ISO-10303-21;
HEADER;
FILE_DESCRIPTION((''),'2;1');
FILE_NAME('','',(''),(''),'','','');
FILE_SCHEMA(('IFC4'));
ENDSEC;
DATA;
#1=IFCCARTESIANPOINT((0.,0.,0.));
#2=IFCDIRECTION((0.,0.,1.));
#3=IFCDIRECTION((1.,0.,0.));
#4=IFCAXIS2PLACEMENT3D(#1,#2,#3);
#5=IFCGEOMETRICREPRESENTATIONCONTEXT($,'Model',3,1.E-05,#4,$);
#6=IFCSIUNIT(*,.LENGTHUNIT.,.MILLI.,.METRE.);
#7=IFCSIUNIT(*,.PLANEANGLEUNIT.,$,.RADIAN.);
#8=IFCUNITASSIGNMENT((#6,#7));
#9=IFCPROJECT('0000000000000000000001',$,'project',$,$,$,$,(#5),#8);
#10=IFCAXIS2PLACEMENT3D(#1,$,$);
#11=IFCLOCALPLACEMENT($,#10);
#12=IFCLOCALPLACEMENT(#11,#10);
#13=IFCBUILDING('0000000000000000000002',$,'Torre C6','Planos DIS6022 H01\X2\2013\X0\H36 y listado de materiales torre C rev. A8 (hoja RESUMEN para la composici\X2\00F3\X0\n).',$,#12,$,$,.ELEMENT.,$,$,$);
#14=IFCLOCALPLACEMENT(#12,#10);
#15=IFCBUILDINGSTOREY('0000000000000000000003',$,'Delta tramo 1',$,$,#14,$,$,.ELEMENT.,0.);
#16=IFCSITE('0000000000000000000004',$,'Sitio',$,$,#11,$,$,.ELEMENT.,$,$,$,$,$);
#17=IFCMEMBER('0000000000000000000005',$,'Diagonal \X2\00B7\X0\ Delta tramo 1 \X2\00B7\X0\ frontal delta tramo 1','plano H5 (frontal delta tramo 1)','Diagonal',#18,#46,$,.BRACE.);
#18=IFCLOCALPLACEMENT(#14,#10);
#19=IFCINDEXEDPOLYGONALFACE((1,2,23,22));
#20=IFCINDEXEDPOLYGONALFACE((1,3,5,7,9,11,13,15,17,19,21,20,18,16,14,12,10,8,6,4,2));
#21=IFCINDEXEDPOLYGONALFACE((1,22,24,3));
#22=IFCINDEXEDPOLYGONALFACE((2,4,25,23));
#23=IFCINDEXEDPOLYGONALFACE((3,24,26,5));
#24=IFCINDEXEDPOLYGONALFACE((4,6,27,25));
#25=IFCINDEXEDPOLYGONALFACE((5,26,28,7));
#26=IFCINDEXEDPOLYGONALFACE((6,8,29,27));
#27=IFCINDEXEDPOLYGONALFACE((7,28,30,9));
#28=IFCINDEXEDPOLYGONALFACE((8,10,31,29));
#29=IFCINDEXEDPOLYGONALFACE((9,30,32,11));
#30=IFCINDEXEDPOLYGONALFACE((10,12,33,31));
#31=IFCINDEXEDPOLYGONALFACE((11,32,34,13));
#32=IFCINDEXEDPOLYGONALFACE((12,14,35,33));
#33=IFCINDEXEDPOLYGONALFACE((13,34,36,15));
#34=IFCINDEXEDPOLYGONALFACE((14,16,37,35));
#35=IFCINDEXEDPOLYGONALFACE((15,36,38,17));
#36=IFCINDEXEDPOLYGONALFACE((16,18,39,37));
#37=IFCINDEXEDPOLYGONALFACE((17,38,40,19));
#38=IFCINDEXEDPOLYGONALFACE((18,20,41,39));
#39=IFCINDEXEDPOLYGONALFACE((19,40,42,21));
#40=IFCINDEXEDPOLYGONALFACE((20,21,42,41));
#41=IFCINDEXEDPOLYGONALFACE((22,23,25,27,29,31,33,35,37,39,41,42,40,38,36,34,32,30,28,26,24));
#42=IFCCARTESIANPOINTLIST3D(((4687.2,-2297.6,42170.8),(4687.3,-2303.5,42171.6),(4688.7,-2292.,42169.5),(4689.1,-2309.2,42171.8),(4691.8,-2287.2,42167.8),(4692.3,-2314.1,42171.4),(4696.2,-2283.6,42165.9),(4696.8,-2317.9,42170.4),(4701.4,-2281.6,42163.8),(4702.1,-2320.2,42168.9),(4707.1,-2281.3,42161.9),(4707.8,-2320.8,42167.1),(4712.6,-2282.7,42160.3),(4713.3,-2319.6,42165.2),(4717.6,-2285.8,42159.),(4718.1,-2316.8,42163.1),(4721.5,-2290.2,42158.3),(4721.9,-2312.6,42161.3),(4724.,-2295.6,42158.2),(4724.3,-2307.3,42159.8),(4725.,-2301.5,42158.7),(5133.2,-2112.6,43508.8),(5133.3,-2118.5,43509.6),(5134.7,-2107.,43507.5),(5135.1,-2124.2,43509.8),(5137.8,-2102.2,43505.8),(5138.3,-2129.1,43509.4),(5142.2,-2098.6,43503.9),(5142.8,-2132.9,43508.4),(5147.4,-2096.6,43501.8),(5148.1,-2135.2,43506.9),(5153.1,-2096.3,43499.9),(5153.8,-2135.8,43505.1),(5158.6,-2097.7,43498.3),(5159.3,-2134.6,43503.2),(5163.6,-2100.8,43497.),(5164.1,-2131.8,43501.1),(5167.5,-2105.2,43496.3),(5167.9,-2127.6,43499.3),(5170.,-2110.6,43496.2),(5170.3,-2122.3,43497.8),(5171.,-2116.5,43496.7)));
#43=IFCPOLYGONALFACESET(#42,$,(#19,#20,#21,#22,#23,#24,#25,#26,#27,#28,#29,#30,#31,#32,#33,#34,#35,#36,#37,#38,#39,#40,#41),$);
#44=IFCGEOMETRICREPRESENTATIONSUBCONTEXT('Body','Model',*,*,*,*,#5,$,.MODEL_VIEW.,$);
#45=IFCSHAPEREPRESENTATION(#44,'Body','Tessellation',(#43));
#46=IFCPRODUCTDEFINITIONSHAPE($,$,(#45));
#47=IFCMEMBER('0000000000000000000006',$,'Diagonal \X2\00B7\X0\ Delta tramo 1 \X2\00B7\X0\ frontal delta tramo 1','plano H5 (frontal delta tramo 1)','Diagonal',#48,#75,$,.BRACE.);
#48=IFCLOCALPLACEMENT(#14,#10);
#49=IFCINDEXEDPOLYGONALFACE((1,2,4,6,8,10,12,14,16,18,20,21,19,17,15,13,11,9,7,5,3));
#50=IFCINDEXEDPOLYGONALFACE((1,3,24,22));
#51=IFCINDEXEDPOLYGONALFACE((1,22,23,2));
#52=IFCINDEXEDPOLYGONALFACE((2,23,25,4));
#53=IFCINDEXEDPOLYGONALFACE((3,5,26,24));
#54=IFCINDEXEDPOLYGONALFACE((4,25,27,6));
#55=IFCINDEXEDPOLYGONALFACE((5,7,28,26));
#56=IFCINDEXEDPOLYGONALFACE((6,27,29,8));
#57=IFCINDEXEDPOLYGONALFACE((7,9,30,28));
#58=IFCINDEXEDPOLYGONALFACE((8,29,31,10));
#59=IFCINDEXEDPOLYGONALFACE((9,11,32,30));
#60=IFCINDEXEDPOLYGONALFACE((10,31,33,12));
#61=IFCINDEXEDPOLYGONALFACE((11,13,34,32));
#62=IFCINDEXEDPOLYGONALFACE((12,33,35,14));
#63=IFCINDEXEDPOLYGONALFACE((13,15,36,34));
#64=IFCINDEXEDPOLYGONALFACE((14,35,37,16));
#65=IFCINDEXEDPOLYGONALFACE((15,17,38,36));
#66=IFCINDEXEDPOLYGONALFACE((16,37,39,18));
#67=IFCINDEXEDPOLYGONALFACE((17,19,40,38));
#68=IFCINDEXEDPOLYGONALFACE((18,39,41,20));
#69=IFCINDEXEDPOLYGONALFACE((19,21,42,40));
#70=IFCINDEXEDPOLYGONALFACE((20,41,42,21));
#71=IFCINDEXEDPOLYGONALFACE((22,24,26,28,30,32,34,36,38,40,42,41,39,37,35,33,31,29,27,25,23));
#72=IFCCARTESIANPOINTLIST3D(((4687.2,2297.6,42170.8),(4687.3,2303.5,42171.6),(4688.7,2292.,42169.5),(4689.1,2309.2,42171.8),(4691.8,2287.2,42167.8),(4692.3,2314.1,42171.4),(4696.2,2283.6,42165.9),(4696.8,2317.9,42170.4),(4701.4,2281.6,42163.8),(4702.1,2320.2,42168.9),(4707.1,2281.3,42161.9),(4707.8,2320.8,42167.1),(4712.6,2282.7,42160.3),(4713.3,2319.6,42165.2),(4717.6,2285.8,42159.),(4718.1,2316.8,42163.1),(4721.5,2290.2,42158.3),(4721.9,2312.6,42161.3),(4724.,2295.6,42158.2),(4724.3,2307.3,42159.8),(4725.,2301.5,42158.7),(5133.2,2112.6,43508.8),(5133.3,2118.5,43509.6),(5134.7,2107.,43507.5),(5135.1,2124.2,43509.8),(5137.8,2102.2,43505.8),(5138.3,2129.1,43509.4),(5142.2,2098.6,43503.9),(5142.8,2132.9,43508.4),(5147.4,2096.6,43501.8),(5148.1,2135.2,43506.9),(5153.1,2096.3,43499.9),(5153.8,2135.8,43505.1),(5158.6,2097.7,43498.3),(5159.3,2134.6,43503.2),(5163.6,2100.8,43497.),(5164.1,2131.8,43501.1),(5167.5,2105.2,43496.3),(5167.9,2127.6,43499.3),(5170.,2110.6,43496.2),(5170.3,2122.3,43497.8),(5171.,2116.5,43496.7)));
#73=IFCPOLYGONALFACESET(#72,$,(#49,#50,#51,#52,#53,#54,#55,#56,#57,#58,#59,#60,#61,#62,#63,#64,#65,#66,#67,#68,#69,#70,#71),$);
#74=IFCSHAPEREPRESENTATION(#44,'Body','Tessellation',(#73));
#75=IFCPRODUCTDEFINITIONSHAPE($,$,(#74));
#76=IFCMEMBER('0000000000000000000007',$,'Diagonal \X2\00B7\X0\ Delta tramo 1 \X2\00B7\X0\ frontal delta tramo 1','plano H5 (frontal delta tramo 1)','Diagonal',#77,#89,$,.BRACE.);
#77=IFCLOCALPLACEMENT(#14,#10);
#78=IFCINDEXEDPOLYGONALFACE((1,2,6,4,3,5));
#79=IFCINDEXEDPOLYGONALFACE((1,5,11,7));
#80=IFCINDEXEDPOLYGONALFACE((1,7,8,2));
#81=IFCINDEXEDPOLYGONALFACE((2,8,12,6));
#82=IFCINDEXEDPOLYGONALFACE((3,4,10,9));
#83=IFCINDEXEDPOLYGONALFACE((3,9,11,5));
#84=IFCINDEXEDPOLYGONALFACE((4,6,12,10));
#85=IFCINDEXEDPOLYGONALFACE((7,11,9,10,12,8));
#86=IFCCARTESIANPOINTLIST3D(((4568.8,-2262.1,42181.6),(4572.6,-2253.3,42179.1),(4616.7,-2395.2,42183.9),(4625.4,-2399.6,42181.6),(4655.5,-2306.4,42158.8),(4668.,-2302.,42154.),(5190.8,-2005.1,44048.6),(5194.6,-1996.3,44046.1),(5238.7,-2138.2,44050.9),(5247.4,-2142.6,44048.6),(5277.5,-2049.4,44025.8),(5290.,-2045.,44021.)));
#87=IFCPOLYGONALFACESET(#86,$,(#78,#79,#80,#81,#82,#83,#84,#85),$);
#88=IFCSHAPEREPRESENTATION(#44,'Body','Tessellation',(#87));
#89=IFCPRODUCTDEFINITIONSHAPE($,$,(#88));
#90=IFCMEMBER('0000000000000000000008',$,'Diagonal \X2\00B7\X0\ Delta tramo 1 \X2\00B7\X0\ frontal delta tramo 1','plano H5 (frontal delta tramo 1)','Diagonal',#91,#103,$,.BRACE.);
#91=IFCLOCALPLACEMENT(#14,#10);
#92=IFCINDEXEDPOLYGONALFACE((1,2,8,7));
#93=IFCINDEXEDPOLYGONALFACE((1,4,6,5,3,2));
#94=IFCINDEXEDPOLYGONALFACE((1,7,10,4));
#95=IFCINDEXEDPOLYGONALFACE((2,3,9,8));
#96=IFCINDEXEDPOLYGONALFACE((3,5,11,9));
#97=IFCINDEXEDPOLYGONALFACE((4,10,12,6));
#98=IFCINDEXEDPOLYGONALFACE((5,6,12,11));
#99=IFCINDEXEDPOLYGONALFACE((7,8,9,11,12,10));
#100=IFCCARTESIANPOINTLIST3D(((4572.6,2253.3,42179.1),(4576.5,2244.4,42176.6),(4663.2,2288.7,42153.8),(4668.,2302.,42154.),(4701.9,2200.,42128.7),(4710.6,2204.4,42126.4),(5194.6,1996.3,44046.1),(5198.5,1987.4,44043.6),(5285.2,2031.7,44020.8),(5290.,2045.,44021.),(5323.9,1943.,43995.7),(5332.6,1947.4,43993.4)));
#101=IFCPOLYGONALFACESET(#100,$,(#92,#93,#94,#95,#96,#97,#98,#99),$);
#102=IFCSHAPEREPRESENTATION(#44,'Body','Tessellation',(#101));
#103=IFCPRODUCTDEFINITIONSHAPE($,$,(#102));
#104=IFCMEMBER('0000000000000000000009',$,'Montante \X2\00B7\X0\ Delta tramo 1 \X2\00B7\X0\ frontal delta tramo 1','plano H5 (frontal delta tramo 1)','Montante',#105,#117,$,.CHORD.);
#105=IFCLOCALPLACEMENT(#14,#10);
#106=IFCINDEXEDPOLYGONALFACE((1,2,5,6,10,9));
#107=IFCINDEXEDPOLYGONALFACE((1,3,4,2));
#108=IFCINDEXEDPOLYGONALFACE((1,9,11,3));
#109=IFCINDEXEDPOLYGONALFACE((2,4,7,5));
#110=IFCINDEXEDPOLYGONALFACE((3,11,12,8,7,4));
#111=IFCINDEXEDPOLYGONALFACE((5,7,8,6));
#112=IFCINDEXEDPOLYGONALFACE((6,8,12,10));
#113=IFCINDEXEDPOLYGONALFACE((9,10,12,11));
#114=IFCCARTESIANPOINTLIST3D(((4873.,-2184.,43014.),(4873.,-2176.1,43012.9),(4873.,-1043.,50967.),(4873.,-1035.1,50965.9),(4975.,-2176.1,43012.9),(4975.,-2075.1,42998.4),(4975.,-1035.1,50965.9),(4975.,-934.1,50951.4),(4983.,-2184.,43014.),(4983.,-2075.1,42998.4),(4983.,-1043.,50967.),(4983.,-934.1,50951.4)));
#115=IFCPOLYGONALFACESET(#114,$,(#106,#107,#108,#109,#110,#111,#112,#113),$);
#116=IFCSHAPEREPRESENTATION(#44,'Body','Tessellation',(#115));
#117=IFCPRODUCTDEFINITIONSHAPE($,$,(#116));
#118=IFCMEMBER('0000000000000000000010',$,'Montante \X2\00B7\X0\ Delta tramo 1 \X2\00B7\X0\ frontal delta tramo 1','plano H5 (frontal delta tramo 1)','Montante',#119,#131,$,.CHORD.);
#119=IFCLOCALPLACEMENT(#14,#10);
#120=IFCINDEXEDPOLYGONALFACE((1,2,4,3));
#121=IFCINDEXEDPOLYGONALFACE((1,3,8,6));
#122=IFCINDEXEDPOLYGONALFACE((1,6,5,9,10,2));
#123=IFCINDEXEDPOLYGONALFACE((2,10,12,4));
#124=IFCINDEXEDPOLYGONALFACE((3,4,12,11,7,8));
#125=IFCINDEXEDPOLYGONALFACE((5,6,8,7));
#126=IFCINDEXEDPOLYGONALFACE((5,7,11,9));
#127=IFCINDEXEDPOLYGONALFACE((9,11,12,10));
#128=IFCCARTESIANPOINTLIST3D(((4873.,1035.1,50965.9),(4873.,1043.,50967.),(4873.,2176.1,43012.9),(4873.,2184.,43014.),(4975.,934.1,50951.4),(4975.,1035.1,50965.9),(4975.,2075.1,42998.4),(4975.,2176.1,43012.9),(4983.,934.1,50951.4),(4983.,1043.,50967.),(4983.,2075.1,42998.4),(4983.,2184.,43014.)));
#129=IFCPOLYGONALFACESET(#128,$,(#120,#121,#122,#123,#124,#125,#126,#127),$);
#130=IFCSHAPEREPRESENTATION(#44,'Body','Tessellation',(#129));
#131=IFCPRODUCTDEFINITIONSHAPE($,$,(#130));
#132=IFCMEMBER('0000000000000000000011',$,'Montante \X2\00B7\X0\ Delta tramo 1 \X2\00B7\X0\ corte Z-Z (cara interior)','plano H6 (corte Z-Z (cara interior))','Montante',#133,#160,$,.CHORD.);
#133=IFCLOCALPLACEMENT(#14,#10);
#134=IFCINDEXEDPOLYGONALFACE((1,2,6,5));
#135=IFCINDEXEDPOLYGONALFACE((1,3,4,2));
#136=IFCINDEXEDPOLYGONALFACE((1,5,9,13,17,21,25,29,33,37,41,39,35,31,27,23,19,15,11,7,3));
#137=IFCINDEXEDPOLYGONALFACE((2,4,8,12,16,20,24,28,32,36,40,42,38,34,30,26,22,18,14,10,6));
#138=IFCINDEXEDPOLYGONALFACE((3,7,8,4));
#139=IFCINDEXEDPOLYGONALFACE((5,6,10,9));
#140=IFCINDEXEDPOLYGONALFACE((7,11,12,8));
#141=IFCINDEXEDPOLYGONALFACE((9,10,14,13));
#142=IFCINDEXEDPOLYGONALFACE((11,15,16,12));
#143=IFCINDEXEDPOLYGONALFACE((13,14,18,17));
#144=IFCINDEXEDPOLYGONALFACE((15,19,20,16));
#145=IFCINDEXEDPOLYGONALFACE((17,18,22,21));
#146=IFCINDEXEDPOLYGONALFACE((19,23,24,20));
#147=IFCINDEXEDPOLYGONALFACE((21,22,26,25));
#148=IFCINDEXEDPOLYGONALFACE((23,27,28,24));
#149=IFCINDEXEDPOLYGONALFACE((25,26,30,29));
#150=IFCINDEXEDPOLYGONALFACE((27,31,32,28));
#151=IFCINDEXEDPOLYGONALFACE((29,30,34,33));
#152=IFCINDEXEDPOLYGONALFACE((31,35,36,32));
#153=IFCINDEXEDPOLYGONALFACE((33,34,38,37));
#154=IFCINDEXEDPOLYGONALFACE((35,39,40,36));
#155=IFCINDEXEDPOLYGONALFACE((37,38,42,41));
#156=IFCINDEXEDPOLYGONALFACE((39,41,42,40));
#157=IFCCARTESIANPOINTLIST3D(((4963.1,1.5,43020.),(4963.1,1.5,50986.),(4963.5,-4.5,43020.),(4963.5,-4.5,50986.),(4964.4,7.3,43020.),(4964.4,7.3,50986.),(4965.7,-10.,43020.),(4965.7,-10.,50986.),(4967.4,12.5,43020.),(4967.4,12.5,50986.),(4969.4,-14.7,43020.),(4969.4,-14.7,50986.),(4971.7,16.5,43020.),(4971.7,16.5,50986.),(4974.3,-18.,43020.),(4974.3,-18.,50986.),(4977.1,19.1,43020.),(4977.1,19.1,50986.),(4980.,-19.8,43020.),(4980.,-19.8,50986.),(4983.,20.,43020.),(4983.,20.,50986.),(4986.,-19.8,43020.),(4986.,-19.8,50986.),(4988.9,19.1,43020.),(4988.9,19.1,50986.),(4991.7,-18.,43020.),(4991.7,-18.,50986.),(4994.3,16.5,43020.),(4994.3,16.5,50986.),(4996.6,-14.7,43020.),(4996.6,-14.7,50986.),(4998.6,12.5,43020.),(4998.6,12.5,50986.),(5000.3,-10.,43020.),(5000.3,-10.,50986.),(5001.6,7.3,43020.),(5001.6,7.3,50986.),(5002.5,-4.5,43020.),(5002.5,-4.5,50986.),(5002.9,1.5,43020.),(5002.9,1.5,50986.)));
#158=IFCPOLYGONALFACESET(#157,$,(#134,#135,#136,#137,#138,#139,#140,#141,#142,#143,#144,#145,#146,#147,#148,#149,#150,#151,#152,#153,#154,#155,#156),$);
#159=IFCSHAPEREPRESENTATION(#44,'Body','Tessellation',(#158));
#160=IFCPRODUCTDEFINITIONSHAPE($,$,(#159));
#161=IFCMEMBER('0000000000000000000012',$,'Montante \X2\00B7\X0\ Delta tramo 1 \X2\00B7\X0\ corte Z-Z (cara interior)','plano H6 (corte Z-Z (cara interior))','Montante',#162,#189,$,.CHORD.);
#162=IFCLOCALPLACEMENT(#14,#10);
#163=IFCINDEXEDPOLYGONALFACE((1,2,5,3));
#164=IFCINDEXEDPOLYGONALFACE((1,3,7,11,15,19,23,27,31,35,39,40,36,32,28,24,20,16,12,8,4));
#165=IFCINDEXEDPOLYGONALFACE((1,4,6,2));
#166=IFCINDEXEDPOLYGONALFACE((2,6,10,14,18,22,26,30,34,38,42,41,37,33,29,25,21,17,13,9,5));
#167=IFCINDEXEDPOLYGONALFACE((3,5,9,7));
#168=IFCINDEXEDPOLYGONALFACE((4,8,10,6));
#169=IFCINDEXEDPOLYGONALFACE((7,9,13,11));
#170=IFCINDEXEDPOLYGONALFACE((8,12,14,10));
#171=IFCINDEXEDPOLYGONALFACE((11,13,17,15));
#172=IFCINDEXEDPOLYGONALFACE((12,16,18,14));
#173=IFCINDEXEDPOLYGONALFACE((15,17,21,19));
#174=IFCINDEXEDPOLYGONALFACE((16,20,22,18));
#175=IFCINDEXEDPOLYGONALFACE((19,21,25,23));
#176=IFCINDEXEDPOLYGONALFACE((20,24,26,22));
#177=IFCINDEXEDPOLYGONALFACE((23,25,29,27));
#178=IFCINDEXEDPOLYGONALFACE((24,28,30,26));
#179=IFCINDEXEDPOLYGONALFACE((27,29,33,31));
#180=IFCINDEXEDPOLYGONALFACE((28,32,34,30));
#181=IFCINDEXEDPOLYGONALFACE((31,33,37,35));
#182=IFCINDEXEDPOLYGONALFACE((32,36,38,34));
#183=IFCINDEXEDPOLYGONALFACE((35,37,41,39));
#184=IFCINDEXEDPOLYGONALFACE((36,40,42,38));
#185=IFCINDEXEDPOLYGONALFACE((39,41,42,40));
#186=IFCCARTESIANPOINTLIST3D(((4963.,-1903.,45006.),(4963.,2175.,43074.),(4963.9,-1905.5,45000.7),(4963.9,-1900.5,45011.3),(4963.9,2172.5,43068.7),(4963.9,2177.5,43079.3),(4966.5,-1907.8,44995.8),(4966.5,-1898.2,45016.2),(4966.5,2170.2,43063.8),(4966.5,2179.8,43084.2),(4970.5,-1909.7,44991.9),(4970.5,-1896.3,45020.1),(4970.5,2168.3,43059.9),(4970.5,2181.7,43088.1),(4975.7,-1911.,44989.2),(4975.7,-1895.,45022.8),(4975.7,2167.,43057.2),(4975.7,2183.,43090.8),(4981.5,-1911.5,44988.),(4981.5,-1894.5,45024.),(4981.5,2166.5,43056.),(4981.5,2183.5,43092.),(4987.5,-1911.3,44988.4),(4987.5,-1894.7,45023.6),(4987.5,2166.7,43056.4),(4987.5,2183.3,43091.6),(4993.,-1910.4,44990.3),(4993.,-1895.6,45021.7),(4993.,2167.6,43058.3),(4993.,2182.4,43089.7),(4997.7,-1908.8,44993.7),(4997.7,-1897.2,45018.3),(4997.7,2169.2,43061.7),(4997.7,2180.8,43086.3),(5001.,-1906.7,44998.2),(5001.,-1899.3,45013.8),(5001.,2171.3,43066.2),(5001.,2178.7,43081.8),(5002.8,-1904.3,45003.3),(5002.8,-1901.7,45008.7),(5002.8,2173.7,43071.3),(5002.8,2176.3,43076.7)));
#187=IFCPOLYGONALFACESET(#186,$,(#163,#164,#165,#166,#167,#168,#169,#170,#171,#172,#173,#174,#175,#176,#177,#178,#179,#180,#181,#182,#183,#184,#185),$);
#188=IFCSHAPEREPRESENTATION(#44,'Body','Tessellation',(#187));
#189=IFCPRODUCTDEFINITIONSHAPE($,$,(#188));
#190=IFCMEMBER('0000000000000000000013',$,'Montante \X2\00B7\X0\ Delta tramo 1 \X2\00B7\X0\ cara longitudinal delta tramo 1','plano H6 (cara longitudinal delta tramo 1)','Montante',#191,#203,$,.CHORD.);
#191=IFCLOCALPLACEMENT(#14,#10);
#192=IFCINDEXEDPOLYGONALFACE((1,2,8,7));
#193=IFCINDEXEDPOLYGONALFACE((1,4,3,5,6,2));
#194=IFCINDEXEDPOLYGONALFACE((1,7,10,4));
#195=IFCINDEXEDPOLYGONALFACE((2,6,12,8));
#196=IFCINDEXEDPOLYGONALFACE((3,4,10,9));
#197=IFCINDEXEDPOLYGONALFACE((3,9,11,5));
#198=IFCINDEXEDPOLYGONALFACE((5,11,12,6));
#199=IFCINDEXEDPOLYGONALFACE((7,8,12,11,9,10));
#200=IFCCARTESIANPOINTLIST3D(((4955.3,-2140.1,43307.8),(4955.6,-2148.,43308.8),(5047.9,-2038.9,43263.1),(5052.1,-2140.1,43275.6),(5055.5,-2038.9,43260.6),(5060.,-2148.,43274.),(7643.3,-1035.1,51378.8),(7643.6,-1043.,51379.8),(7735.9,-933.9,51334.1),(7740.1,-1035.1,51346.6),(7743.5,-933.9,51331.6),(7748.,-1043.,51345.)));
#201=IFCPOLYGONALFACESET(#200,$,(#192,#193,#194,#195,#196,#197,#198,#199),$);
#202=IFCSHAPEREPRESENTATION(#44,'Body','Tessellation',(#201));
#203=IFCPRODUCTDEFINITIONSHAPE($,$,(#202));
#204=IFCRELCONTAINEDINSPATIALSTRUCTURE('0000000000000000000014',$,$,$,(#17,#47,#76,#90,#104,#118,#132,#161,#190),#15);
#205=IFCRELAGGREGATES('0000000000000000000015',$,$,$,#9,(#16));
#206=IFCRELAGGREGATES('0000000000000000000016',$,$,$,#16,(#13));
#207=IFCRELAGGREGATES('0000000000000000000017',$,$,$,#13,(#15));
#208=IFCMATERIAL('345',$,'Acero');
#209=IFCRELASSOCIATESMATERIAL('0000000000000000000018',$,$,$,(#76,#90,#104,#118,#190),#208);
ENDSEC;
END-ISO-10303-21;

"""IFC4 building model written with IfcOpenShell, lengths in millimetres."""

from ifc_helpers import new_model, si_unit, frame, frame_2d, origin, origin_with_axes, place, context, subcontext, project, spatial, circle, l_section, extrude, material, element, save


model = new_model("IFC4")

# Units and contexts
model_context = context("Model", 3, precision=1e-05, world=origin_with_axes())
body_context = subcontext(model_context, "Body", "Model", "MODEL_VIEW")
ifc_project = project(units=[si_unit("LENGTHUNIT", "METRE", prefix="MILLI"), si_unit("PLANEANGLEUNIT", "RADIAN")], contexts=[model_context])

# Site, building, storey
site_placement = place(None, origin())
site = spatial("IfcSite", under=ifc_project, at=site_placement, Name="Sitio", CompositionType="ELEMENT")
building_placement = place(site_placement, origin())
building = spatial("IfcBuilding", under=site, at=building_placement, Name="Torre C6", Description="Planos DIS6022 H01–H36 y listado de materiales torre C rev. A8 (hoja RESUMEN para la composición).", CompositionType="ELEMENT")
storey_placement = place(building_placement, origin())
storey = spatial("IfcBuildingStorey", under=building, at=storey_placement, Name="Delta tramo 1", CompositionType="ELEMENT", Elevation=0.0)

# Members
for number, where, z_axis, x_axis, name in (
    (1, (4706.0, -2301.0, 42165.0), (0.313542, 0.130057, 0.940626), (-0.863292, 0.451616, 0.225321), "Diagonal · Delta tramo 1 · frontal delta tramo 1"),
    (2, (4706.0, 2301.0, 42165.0), (0.313542, -0.130057, 0.940626), (-0.863292, -0.451616, 0.225321), "Diagonal · Delta tramo 1 · frontal delta tramo 1"),
):
    element("IfcMember", number, at=place(storey_placement, frame(where, z_axis=z_axis, x_axis=x_axis)), inside=storey, Name=name, Description="plano H5 (frontal delta tramo 1)", ObjectType="Diagonal", PredefinedType="BRACE", context=body_context, shape_type="SweptSolid", body=[
        extrude(circle(Radius=20.0), None, (0.0, 0.0, 1.0), 1422.5),
    ])
ifc_material_1 = material(Name="345", Category="Acero")
for number, where, z_axis, x_axis, name in (
    (3, (4668.0, -2302.0, 42154.0), (0.313414, 0.129497, 0.940746), (-0.867067, 0.443015, 0.227885), "Diagonal · Delta tramo 1 · frontal delta tramo 1"),
    (4, (4668.0, 2302.0, 42154.0), (0.313414, -0.129497, 0.940746), (-0.867067, -0.443015, 0.227885), "Diagonal · Delta tramo 1 · frontal delta tramo 1"),
):
    element("IfcMember", number, at=place(storey_placement, frame(where, z_axis=z_axis, x_axis=x_axis)), inside=storey, material=ifc_material_1, Name=name, Description="plano H5 (frontal delta tramo 1)", ObjectType="Diagonal", PredefinedType="BRACE", context=body_context, shape_type="SweptSolid", body=[
        extrude(l_section(Depth=110.0, Width=110.0, Thickness=10.0, at=frame_2d((55.0, 55.0))), None, (0.0, 0.0, 1.0), 1984.6),
    ])
for number, where, z_axis, x_axis, name in (
    (5, (4983.0, -2184.0, 43014.0), (0.0, 0.142014, 0.989865), (0.0, 0.989865, -0.142014), "Montante · Delta tramo 1 · frontal delta tramo 1"),
    (6, (4983.0, 2184.0, 43014.0), (0.0, -0.142014, 0.989865), (-1.0, 0.0, 0.0), "Montante · Delta tramo 1 · frontal delta tramo 1"),
):
    element("IfcMember", number, at=place(storey_placement, frame(where, z_axis=z_axis, x_axis=x_axis)), inside=storey, material=ifc_material_1, Name=name, Description="plano H5 (frontal delta tramo 1)", ObjectType="Montante", PredefinedType="CHORD", context=body_context, shape_type="SweptSolid", body=[
        extrude(l_section(Depth=110.0, Width=110.0, Thickness=8.0, at=frame_2d((55.0, 55.0))), None, (0.0, 0.0, 1.0), 8034.4),
    ])
member_1_placement = place(storey_placement, frame((4983.0, 0.0, 43020.0), z_axis=(0.0, 0.0, 1.0), x_axis=(0.0, 1.0, 0.0)))
element("IfcMember", 7, at=member_1_placement, inside=storey, Name="Montante · Delta tramo 1 · corte Z-Z (cara interior)", Description="plano H6 (corte Z-Z (cara interior))", ObjectType="Montante", PredefinedType="CHORD", context=body_context, shape_type="SweptSolid", body=[
    extrude(circle(Radius=20.0), None, (0.0, 0.0, 1.0), 7966.0),
])
member_2_placement = place(storey_placement, frame((4983.0, 2175.0, 43074.0), z_axis=(0.0, -0.903711, 0.428144), x_axis=(-1.0, 0.0, 0.0)))
element("IfcMember", 8, at=member_2_placement, inside=storey, Name="Montante · Delta tramo 1 · corte Z-Z (cara interior)", Description="plano H6 (corte Z-Z (cara interior))", ObjectType="Montante", PredefinedType="CHORD", context=body_context, shape_type="SweptSolid", body=[
    extrude(circle(Radius=20.0), None, (0.0, 0.0, 1.0), 4512.5),
])
member_3_placement = place(storey_placement, frame((5060.0, -2148.0, 43274.0), z_axis=(0.313348, 0.128813, 0.940861), x_axis=(-0.040703, 0.991669, -0.122214)))
element("IfcMember", 9, at=member_3_placement, inside=storey, material=ifc_material_1, Name="Montante · Delta tramo 1 · cara longitudinal delta tramo 1", Description="plano H6 (cara longitudinal delta tramo 1)", ObjectType="Montante", PredefinedType="CHORD", context=body_context, shape_type="SweptSolid", body=[
    extrude(l_section(Depth=110.0, Width=110.0, Thickness=8.0, at=frame_2d((55.0, 55.0))), None, (0.0, 0.0, 1.0), 8578.3),
])

save(model, "model.ifc")
